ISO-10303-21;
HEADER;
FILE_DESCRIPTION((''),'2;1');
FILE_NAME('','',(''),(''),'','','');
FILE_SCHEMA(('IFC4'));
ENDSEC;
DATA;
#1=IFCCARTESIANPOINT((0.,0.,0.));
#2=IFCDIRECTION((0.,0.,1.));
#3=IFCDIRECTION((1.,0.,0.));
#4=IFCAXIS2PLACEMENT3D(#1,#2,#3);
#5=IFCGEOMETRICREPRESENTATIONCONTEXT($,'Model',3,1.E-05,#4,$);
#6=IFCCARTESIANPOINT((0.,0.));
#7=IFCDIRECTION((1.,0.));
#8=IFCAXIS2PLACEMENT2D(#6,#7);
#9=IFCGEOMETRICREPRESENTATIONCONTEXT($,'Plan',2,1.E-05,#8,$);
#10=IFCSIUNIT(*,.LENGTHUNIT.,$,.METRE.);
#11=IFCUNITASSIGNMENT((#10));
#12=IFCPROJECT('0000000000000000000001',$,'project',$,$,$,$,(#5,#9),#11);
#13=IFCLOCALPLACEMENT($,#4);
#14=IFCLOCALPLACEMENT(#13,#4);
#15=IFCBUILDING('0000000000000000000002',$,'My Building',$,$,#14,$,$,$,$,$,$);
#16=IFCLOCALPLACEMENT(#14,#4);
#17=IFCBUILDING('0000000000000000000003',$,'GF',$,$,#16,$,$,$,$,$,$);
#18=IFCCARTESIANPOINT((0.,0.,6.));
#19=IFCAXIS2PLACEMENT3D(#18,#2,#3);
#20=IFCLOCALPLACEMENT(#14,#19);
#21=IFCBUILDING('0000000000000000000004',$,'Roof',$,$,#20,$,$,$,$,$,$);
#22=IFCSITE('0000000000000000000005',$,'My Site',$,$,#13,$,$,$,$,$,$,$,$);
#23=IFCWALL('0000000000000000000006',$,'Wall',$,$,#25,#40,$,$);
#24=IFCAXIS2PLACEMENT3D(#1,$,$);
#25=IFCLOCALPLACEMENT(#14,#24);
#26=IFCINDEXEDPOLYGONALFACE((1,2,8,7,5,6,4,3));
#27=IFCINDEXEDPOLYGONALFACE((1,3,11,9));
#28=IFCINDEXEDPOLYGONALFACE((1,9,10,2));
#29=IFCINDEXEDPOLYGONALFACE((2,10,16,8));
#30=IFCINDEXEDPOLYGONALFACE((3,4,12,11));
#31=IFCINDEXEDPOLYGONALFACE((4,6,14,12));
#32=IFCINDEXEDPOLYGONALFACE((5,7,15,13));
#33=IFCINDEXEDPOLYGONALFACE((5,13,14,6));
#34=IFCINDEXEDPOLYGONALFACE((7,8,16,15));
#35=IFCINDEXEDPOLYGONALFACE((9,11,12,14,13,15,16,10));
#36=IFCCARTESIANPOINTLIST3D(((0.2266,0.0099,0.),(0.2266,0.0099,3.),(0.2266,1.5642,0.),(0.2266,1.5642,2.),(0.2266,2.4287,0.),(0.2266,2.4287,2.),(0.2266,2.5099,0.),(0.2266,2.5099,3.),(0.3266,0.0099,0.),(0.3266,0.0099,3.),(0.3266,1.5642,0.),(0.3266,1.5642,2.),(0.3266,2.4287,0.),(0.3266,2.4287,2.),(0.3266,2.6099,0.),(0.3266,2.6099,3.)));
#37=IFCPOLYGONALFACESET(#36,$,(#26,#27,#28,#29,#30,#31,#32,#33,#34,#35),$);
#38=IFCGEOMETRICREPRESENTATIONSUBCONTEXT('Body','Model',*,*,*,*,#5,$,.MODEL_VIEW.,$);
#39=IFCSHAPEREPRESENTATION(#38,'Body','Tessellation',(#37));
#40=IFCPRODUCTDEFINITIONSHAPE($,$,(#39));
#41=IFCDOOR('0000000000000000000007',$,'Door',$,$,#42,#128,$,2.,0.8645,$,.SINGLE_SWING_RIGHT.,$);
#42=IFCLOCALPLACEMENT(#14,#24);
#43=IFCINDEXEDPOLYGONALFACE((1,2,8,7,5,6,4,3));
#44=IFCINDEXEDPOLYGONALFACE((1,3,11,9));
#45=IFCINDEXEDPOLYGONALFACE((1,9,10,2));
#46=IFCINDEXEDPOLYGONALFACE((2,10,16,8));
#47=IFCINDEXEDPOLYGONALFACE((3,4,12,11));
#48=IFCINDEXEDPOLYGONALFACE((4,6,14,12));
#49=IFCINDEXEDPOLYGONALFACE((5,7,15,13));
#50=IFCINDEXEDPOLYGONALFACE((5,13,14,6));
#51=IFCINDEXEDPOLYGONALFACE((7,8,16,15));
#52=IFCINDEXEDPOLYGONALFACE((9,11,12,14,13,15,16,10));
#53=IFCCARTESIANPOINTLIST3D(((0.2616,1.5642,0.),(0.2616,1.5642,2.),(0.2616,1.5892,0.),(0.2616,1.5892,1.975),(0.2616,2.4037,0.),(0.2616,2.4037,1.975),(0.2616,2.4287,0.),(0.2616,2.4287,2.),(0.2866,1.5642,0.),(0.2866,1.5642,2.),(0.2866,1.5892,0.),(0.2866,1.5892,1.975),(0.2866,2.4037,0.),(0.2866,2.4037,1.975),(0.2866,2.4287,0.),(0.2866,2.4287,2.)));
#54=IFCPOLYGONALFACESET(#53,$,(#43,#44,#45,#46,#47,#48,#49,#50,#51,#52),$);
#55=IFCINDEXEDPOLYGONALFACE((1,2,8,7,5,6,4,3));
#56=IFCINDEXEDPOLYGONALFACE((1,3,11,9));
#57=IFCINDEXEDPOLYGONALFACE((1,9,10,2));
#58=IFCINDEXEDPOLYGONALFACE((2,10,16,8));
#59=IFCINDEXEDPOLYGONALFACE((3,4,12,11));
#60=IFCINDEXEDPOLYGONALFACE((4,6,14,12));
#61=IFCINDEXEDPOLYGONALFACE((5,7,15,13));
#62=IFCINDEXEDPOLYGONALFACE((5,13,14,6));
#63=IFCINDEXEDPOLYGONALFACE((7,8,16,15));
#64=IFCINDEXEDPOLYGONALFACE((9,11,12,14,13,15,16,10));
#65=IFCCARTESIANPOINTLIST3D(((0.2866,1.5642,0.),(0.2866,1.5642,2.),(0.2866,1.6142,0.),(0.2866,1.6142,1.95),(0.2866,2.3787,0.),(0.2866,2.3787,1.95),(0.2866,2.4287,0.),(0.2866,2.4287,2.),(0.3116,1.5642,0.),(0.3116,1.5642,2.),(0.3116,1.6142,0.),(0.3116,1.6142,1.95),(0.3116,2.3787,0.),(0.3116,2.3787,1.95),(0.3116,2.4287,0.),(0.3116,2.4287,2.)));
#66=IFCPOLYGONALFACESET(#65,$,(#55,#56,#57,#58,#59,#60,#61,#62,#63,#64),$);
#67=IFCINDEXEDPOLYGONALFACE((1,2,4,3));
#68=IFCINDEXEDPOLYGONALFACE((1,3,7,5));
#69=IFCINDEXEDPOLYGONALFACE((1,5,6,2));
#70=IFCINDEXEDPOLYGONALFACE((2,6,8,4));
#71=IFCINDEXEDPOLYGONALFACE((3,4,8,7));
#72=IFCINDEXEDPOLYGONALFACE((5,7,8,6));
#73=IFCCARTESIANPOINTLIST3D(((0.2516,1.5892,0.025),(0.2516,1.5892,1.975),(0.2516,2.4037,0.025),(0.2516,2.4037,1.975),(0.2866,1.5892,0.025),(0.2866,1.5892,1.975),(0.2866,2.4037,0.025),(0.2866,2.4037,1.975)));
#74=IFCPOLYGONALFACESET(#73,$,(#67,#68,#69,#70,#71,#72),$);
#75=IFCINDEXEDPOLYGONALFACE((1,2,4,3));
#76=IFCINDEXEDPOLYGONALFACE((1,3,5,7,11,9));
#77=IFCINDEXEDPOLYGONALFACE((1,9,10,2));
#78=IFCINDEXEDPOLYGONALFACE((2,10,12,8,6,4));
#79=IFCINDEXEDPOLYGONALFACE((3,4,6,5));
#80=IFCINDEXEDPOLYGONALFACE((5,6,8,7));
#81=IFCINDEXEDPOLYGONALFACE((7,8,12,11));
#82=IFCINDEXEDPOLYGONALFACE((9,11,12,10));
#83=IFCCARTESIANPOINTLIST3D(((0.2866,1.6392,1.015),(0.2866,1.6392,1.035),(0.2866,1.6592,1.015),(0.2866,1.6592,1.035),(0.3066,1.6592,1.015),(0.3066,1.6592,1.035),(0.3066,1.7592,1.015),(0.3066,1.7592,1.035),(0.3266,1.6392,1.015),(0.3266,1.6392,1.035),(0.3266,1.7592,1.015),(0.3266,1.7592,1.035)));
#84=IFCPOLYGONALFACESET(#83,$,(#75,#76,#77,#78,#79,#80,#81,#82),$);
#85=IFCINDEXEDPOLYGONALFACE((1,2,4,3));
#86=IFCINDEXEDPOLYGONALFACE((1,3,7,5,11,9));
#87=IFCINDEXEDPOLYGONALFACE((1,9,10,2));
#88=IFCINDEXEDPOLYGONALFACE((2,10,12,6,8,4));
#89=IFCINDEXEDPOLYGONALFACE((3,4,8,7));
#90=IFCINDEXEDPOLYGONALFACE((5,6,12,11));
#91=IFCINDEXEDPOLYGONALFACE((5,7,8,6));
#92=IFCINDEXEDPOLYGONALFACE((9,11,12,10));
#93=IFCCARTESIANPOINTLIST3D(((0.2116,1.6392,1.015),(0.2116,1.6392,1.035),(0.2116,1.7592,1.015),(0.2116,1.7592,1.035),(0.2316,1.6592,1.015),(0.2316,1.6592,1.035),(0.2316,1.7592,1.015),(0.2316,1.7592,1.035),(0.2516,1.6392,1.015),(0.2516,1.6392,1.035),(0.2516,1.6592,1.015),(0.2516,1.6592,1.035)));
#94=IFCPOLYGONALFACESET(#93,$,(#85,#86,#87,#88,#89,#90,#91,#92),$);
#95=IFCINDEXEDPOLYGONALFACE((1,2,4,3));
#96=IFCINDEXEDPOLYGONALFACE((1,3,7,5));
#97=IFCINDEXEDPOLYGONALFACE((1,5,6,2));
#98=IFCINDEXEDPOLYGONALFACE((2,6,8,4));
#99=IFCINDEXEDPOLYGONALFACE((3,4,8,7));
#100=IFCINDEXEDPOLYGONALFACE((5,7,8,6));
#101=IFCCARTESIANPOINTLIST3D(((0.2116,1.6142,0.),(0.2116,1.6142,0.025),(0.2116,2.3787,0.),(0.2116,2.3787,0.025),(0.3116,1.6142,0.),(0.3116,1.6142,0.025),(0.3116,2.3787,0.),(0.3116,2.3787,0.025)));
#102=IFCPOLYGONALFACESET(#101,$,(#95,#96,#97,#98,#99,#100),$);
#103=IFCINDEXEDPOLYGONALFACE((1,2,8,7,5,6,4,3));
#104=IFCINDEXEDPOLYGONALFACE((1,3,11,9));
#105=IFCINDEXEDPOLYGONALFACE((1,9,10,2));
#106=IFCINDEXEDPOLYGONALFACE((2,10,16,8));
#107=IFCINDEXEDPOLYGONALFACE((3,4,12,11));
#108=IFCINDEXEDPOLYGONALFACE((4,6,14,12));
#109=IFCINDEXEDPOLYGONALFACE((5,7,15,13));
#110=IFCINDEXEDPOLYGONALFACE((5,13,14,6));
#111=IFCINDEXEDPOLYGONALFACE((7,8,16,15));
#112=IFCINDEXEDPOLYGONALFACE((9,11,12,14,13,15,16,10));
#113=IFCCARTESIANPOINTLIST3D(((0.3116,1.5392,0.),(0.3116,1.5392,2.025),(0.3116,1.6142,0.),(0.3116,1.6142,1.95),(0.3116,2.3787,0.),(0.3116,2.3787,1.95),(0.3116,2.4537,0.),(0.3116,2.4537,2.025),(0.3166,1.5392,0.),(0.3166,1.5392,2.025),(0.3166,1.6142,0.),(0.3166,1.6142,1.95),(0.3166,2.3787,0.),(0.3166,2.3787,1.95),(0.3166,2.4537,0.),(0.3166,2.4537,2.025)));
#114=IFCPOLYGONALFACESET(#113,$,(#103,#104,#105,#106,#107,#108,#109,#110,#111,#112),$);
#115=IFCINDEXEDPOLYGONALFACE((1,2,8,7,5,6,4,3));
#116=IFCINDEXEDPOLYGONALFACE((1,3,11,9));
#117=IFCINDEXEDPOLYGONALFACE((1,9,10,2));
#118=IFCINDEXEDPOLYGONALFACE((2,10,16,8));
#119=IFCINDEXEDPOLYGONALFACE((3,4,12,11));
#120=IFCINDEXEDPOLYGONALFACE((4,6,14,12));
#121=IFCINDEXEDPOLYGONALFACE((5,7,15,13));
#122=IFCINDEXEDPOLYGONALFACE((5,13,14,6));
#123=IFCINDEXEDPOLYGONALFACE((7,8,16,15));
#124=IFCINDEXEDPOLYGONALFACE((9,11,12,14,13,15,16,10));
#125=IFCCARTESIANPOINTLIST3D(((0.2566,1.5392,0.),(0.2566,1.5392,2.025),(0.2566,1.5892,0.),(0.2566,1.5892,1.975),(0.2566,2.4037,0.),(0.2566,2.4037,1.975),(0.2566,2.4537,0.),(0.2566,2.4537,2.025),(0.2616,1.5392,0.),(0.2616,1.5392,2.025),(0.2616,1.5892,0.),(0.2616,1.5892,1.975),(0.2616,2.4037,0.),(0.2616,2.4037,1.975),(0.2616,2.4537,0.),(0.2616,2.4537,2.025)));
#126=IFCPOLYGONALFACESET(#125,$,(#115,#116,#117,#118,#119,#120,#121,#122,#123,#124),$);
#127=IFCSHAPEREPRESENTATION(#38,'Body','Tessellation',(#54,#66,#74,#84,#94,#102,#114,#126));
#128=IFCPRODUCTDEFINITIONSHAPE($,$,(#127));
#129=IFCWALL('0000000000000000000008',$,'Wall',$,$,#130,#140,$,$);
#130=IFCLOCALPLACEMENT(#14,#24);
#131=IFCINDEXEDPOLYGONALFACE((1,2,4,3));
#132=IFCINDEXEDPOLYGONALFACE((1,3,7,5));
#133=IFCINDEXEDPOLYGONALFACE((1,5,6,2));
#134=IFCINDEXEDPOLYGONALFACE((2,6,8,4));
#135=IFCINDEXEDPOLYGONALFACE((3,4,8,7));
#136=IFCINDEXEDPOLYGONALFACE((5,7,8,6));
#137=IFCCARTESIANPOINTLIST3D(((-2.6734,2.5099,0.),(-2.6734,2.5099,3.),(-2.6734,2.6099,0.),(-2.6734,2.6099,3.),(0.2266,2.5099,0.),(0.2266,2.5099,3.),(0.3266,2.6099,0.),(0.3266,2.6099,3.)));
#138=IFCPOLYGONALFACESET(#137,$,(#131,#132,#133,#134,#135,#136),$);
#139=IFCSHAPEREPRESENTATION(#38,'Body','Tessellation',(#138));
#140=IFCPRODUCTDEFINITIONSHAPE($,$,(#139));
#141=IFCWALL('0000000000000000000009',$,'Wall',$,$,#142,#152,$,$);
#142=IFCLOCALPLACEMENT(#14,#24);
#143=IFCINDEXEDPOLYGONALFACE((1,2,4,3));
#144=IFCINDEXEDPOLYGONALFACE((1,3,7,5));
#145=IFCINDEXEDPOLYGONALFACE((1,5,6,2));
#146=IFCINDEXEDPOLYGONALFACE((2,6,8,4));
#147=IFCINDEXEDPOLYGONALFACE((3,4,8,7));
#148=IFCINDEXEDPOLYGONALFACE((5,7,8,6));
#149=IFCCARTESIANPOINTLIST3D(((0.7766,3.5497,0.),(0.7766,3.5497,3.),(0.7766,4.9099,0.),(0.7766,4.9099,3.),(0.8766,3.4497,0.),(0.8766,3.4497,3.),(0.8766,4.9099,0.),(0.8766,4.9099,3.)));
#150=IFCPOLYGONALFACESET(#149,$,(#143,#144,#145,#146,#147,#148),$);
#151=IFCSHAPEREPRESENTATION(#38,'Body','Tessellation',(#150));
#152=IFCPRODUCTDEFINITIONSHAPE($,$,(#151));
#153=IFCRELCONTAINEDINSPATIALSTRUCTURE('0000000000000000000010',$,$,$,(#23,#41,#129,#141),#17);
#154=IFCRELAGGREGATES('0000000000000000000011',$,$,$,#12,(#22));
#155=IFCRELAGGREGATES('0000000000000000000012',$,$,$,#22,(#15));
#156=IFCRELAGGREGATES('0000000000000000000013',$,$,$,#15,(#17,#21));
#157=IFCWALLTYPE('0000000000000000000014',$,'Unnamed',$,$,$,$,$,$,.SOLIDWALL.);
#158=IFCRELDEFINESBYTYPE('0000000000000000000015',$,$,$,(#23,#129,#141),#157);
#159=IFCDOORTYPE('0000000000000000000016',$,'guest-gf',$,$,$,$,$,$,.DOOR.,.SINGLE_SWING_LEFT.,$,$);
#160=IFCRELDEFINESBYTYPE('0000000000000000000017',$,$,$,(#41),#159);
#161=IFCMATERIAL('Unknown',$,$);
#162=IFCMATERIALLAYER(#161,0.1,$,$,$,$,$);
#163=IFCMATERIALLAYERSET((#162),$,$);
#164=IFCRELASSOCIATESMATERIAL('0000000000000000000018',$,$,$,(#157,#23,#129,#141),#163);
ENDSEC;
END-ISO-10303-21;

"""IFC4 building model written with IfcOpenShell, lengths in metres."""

from ifc_helpers import new_model, entity, si_unit, frame, origin_with_axes, origin_2d_with_axis, place, context, subcontext, project, spatial, line, indexed_curve, outline, extrude, shape, source, transform, mapped, material, layer, layer_set, layer_usage, type_object, type_shapes, element, fill, save


model = new_model("IFC4")

# Units and contexts
model_context = context("Model", 3, precision=1e-05, world=origin_with_axes())
plan_context = context("Plan", 2, precision=1e-05, world=origin_2d_with_axis())
body_context_1 = subcontext(model_context, "Body", "Model", "MODEL_VIEW")
body_context_2 = subcontext(plan_context, "Body", "Plan", "PLAN_VIEW")
ifc_project = project(units=[si_unit("LENGTHUNIT", "METRE")], contexts=[model_context, plan_context])

# Site, buildings
site_placement = place(None, origin_with_axes())
site = spatial("IfcSite", under=ifc_project, at=site_placement, Name="My Site")
building_1_placement = place(site_placement, origin_with_axes())
building_1 = spatial("IfcBuilding", under=site, at=building_1_placement, Name="My Building")
building_2_placement = place(building_1_placement, origin_with_axes())
building_2 = spatial("IfcBuilding", under=building_1, at=building_2_placement, Name="GF")

# Shared definitions
ifc_material = material(Name="Unknown")

# Shared definitions
building_3_placement = place(building_1_placement, frame((0.0, 0.0, 6.0), z_axis=(0.0, 0.0, 1.0), x_axis=(1.0, 0.0, 0.0)))
building_3 = spatial("IfcBuilding", under=building_1, at=building_3_placement, Name="Roof")

# Shared definitions
ifc_layer_1 = layer(ifc_material, 0.1)
ifc_layer_set_1 = layer_set([ifc_layer_1])
wall_type = type_object("IfcWallType", Name="Unnamed", PredefinedType="SOLIDWALL", material=ifc_layer_set_1)

# Wall, opening, door
ifc_layer_usage_1 = layer_usage(ifc_layer_set_1, "AXIS2", "POSITIVE", 0.0)
wall_1_placement = place(building_2_placement, frame((0.3266, 0.0099, 0.0), z_axis=(0.0, 0.0, 1.0), x_axis=(0.0, 1.0, 0.0)))
wall_1 = element("IfcWall", 1, at=wall_1_placement, inside=building_2, type_object=wall_type, material=ifc_layer_usage_1, Name="Wall", context=body_context_1, shape_type="SweptSolid", body=[
    extrude(outline(indexed_curve([(0.0, 0.0), (0.0, 0.1), (2.5, 0.1), (2.6, 0.0)], segments=[line(1, 2, 3, 4, 1)])), origin_with_axes(), (0.0, 0.0, 1.0), 3.0),
])
shared_shape_1 = source(origin_with_axes(), body_context_1, "Body", "SweptSolid", [
    extrude(outline(indexed_curve([(0.0, 0.0), (0.8645, 0.0), (0.8645, 2.0), (0.0, 2.0)], segments=[line(1, 2, 3, 4, 1)])), frame((0.0, -0.6, 0.0), z_axis=(0.0, -1.0, 0.0), x_axis=(1.0, 0.0, 0.0)), (0.0, 0.0, -1.0), 1.2),
])
opening_1_placement = place(wall_1_placement, frame((1.5543, 0.015, 0.0), z_axis=(0.0, 0.0, 1.0), x_axis=(1.0, 0.0, 0.0)))
opening_1 = element("IfcOpeningElement", 2, at=opening_1_placement, cuts=wall_1, PredefinedType="OPENING", context=body_context_1, shape_type="MappedRepresentation", body=[
    mapped(shared_shape_1, transform((0.0, 0.0, 0.0), x_axis=(1.0, 0.0, 0.0), y_axis=(0.0, 1.0, 0.0), z_axis=(0.0, 0.0, 1.0), scale=1.0)),
])
door_type_1 = type_object("IfcDoorType", Name="guest-gf", OperationType="SINGLE_SWING_LEFT", PredefinedType="DOOR")
shared_shape_2 = source(origin_with_axes(), body_context_1, "Body", "SweptSolid", [
    extrude(outline(indexed_curve([(0.0, 0.0), (0.0, 2.0), (0.8645, 2.0), (0.8645, 0.0), (0.8395, 0.0), (0.8395, 1.975), (0.025, 1.975), (0.025, 0.0)], segments=[line(1, 2, 3, 4, 5, 6, 7, 8, 1)])), frame((0.0, 0.025, 0.0), z_axis=(0.0, -1.0, 0.0), x_axis=(1.0, 0.0, 0.0)), (0.0, 0.0, -1.0), 0.025),
    extrude(outline(indexed_curve([(0.0, 0.0), (0.0, 2.0), (0.8645, 2.0), (0.8645, 0.0), (0.8145, 0.0), (0.8145, 1.95), (0.05, 1.95), (0.05, 0.0)], segments=[line(1, 2, 3, 4, 5, 6, 7, 8, 1)])), frame((0.0, 0.0, 0.0), z_axis=(0.0, -1.0, 0.0), x_axis=(1.0, 0.0, 0.0)), (0.0, 0.0, -1.0), 0.025),
    extrude(outline(indexed_curve([(0.0, 0.0), (0.8145, 0.0), (0.8145, 0.035), (0.0, 0.035)], segments=[line(1, 2, 3, 4, 1)])), frame((0.025, 0.025, 0.025), z_axis=(0.0, 0.0, 1.0), x_axis=(1.0, 0.0, 0.0)), (0.0, 0.0, 1.0), 1.95),
    extrude(outline(indexed_curve([(0.0, 0.0), (0.0, -0.04), (0.12, -0.04), (0.12, -0.02), (0.02, -0.02), (0.02, 0.0)], segments=[line(1, 2, 3, 4, 5, 6, 1)])), frame((0.075, 0.025, 1.015), z_axis=(0.0, 0.0, 1.0), x_axis=(1.0, 0.0, 0.0)), (0.0, 0.0, 1.0), 0.02),
    extrude(outline(indexed_curve([(0.0, 0.0), (0.0, 0.04), (0.12, 0.04), (0.12, 0.02), (0.02, 0.02), (0.02, 0.0)], segments=[line(1, 2, 3, 4, 5, 6, 1)])), frame((0.075, 0.06, 1.015), z_axis=(0.0, 0.0, 1.0), x_axis=(1.0, 0.0, 0.0)), (0.0, 0.0, 1.0), 0.02),
    extrude(outline(indexed_curve([(0.0, 0.0), (0.7645, 0.0), (0.7645, 0.1), (0.0, 0.1)], segments=[line(1, 2, 3, 4, 1)])), frame((0.05, 0.0, 0.0), z_axis=(0.0, 0.0, 1.0), x_axis=(1.0, 0.0, 0.0)), (0.0, 0.0, 1.0), 0.025),
    extrude(outline(indexed_curve([(0.0, 0.0), (0.0, 2.025), (0.9145, 2.025), (0.9145, 0.0), (0.8395, 0.0), (0.8395, 1.95), (0.075, 1.95), (0.075, 0.0)], segments=[line(1, 2, 3, 4, 5, 6, 7, 8, 1)])), frame((-0.025, -0.005, 0.0), z_axis=(0.0, -1.0, 0.0), x_axis=(1.0, 0.0, 0.0)), (0.0, 0.0, -1.0), 0.005),
    extrude(outline(indexed_curve([(0.0, 0.0), (0.0, 2.025), (0.9145, 2.025), (0.9145, 0.0), (0.8645, 0.0), (0.8645, 1.975), (0.05, 1.975), (0.05, 0.0)], segments=[line(1, 2, 3, 4, 5, 6, 7, 8, 1)])), frame((-0.025, 0.05, 0.0), z_axis=(0.0, -1.0, 0.0), x_axis=(1.0, 0.0, 0.0)), (0.0, 0.0, -1.0), 0.005),
])
shared_shape_3 = source(origin_with_axes(), body_context_2, "Body", "Curve2D", [
    entity("IfcIndexedPolyCurve", entity("IfcCartesianPointList2D", [[0.0, 0.0], [0.0, 0.05], [0.025, 0.05], [0.025, 0.025], [0.05, 0.025], [0.05, 0.0]]), [entity("IfcLineIndex", [1, 2, 3, 4, 5, 6, 1])]),
    entity("IfcIndexedPolyCurve", entity("IfcCartesianPointList2D", [[0.8645, 0.0], [0.8645, 0.05], [0.8395, 0.05], [0.8395, 0.025], [0.8145, 0.025], [0.8145, 0.0]]), [entity("IfcLineIndex", [1, 2, 3, 4, 5, 6, 1])]),
    entity("IfcTrimmedCurve", entity("IfcEllipse", entity("IfcAxis2Placement2D", entity("IfcCartesianPoint", [0.8045, 0.05]), entity("IfcDirection", [1.0, 0.0])), 0.7795, 0.8145), [entity("IfcCartesianPoint", [0.8045, 0.8645])], [entity("IfcCartesianPoint", [0.025, 0.05])], True, "CARTESIAN"),
    entity("IfcIndexedPolyCurve", entity("IfcCartesianPointList2D", [[0.8395, 0.05], [0.8045, 0.05], [0.8045, 0.8645], [0.8395, 0.8645]]), [entity("IfcLineIndex", [1, 2, 3, 4, 1])]),
])
type_shapes(door_type_1, [shared_shape_2, shared_shape_3])
door_1_placement = place(opening_1_placement, frame((0.0, 0.0, 0.0), z_axis=(0.0, 0.0, 1.0), x_axis=(1.0, 0.0, 0.0)))
door_1 = element("IfcDoor", 3, at=door_1_placement, inside=building_2, type_object=door_type_1, Name="Door", OperationType="SINGLE_SWING_RIGHT", OverallHeight=2.0, OverallWidth=0.8645, shapes=[
    shape(body_context_1, "Body", "MappedRepresentation", [mapped(shared_shape_2, transform((0.0, 0.0, 0.0), x_axis=(1.0, 0.0, 0.0), y_axis=(0.0, 1.0, 0.0), z_axis=(0.0, 0.0, 1.0), scale=1.0))]),
    shape(body_context_2, "Body", "MappedRepresentation", [mapped(shared_shape_3, transform((0.0, 0.0, 0.0), x_axis=(1.0, 0.0, 0.0), y_axis=(0.0, 1.0, 0.0), z_axis=(0.0, 0.0, 1.0), scale=1.0))]),
])
fill(opening_1, door_1)

# Walls
ifc_layer_usage_2 = layer_usage(ifc_layer_set_1, "AXIS2", "POSITIVE", 0.0)
wall_2_placement = place(building_2_placement, frame((0.3266, 2.6099, 0.0), z_axis=(0.0, 0.0, 1.0), x_axis=(-1.0, 0.0, 0.0)))
element("IfcWall", 4, at=wall_2_placement, inside=building_2, type_object=wall_type, material=ifc_layer_usage_2, Name="Wall", context=body_context_1, shape_type="SweptSolid", body=[
    extrude(outline(indexed_curve([(0.0, 0.0), (0.1, 0.1), (3.0, 0.1), (3.0, 0.0)], segments=[line(1, 2, 3, 4, 1)])), origin_with_axes(), (0.0, 0.0, 1.0), 3.0),
])
ifc_layer_usage_3 = layer_usage(ifc_layer_set_1, "AXIS2", "POSITIVE", 0.0)
wall_3_placement = place(building_2_placement, frame((0.8766, 3.5497, 0.0), z_axis=(0.0, 0.0, 1.0), x_axis=(0.0, 1.0, 0.0)))
element("IfcWall", 5, at=wall_3_placement, inside=building_2, type_object=wall_type, material=ifc_layer_usage_3, Name="Wall", context=body_context_1, shape_type="SweptSolid", body=[
    extrude(outline(indexed_curve([(-0.1, 0.0), (0.0, 0.1), (1.3602, 0.1), (1.3602, 0.0)], segments=[line(1, 2, 3, 4, 1)])), origin_with_axes(), (0.0, 0.0, 1.0), 3.0),
])

save(model, "model.ifc")
